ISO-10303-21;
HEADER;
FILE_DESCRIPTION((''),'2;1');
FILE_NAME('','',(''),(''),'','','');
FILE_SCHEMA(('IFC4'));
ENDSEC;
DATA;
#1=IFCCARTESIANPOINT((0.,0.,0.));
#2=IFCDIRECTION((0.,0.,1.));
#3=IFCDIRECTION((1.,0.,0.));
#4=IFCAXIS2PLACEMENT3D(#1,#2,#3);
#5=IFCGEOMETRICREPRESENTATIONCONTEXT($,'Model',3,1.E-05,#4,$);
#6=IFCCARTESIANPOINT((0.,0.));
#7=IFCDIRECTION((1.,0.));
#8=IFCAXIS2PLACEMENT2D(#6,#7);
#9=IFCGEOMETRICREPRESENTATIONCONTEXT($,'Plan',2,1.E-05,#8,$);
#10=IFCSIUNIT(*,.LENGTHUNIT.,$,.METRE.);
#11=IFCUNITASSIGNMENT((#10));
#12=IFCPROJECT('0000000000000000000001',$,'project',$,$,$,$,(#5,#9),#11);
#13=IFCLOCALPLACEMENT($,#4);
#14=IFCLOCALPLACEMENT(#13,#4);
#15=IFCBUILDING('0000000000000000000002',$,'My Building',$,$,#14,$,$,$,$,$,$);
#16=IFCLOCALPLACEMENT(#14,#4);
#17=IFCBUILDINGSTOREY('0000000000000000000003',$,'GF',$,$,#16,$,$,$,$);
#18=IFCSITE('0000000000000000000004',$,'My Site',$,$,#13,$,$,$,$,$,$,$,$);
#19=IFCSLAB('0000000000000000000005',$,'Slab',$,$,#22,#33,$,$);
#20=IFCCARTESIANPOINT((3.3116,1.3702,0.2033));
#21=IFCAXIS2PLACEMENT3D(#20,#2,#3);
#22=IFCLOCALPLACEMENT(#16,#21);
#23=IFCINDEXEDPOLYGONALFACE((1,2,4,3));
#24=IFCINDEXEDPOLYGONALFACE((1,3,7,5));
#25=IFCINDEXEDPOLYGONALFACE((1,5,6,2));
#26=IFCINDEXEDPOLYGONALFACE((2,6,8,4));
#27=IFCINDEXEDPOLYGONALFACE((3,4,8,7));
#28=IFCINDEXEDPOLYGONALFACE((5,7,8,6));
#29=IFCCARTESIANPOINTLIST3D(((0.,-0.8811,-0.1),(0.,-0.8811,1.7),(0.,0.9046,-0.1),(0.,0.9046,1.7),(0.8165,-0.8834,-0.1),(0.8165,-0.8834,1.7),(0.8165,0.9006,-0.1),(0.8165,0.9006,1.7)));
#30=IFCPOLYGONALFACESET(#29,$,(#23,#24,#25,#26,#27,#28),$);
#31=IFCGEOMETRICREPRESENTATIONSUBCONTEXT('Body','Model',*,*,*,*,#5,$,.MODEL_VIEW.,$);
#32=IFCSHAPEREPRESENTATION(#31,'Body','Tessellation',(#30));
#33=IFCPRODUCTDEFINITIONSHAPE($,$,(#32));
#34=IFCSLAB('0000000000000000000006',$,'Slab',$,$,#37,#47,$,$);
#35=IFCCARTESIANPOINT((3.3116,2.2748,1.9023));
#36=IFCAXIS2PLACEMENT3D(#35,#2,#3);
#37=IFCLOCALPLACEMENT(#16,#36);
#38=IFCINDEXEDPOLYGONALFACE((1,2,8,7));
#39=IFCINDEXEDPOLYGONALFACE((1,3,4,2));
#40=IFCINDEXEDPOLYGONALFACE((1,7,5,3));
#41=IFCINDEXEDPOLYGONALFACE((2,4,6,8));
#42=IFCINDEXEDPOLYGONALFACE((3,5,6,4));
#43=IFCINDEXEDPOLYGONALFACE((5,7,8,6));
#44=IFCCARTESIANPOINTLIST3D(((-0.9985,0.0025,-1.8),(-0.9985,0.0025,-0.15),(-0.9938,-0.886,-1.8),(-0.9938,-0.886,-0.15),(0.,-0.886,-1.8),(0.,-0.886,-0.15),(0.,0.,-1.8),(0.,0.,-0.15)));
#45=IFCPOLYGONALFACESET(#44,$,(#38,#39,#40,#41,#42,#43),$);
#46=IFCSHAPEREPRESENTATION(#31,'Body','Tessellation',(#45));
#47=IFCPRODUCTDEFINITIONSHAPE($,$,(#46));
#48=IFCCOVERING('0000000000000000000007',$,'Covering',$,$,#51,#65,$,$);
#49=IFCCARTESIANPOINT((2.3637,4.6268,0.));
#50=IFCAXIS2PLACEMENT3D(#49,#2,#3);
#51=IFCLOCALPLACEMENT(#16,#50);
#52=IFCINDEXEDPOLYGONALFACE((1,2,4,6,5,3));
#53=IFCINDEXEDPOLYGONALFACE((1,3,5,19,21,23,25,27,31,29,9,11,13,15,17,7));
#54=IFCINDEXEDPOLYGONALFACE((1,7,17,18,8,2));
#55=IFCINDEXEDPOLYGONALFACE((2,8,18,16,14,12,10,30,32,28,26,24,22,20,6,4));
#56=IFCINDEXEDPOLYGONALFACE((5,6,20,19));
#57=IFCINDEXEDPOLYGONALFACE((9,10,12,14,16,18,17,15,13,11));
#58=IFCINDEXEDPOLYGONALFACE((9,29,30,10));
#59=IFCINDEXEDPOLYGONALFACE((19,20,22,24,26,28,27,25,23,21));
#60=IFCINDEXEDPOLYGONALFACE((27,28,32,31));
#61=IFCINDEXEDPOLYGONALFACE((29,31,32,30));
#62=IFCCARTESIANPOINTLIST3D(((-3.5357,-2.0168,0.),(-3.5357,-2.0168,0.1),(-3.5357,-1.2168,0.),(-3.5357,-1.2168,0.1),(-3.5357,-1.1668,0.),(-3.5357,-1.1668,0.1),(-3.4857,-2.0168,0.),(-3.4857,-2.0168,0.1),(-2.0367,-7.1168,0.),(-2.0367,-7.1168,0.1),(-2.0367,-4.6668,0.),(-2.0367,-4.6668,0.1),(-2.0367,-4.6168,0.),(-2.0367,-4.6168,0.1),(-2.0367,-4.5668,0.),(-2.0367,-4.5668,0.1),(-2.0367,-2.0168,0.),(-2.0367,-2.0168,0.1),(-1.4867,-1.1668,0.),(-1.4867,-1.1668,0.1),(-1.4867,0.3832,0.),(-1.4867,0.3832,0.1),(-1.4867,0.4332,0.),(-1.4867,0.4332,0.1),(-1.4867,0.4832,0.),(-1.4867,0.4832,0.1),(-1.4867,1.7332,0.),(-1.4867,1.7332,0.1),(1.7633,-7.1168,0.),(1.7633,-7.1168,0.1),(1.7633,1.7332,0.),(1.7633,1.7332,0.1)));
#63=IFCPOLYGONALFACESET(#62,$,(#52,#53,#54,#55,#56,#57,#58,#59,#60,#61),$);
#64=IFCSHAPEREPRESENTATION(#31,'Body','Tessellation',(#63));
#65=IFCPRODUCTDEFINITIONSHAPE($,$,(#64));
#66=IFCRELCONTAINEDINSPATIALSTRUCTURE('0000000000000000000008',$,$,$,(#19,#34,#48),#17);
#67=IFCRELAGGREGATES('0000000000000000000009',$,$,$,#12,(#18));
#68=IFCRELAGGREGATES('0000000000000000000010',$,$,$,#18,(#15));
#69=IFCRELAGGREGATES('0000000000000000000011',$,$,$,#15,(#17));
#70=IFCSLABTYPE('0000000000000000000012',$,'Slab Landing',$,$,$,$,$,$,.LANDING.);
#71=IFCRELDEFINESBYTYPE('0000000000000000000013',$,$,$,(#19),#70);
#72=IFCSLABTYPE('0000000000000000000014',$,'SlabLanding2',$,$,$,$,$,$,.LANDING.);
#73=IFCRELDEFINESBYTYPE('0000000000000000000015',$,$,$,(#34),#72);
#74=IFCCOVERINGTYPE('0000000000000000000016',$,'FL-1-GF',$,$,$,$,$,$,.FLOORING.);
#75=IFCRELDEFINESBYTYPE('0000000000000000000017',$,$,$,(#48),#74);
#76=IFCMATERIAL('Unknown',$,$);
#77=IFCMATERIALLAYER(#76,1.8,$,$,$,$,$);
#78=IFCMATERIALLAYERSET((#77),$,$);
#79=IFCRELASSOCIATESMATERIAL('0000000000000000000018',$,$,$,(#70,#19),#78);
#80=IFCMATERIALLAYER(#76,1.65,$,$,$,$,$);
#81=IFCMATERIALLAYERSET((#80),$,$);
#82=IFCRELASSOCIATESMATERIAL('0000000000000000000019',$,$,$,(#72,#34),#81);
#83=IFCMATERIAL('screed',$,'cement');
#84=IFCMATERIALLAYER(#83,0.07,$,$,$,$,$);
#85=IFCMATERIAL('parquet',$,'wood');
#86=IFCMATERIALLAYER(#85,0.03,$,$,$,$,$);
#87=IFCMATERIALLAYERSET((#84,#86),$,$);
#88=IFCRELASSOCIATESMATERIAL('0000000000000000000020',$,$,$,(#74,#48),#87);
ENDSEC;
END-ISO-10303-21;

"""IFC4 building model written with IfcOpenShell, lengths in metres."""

from ifc_helpers import new_model, si_unit, frame, origin_with_axes, origin_2d_with_axis, place, context, subcontext, project, spatial, line, indexed_curve, outline, extrude, material, layer, layer_set, layer_usage, type_object, element, save


model = new_model("IFC4")

# Units and contexts
model_context = context("Model", 3, precision=1e-05, world=origin_with_axes())
plan_context = context("Plan", 2, precision=1e-05, world=origin_2d_with_axis())
body_context_1 = subcontext(model_context, "Body", "Model", "MODEL_VIEW")
ifc_project = project(units=[si_unit("LENGTHUNIT", "METRE")], contexts=[model_context, plan_context])

# Site, building, storey
site_placement = place(None, origin_with_axes())
site = spatial("IfcSite", under=ifc_project, at=site_placement, Name="My Site")
building_placement = place(site_placement, origin_with_axes())
building = spatial("IfcBuilding", under=site, at=building_placement, Name="My Building")
storey_placement = place(building_placement, origin_with_axes())
storey = spatial("IfcBuildingStorey", under=building, at=storey_placement, Name="GF")

# Slabs
ifc_material_1 = material(Name="Unknown")
ifc_layer_1 = layer(ifc_material_1, 1.8)
ifc_layer_set_1 = layer_set([ifc_layer_1])
ifc_layer_usage_1 = layer_usage(ifc_layer_set_1, "AXIS3", "POSITIVE", -0.1)
slab_type_1 = type_object("IfcSlabType", Name="Slab Landing", PredefinedType="LANDING", material=ifc_layer_set_1)
slab_1_placement = place(storey_placement, frame((3.3116, 1.3702, 0.2033), z_axis=(0.0, 0.0, 1.0), x_axis=(1.0, 0.0, 0.0)))
element("IfcSlab", 1, at=slab_1_placement, inside=storey, type_object=slab_type_1, material=ifc_layer_usage_1, Name="Slab", context=body_context_1, shape_type="SweptSolid", body=[
    extrude(outline(indexed_curve([(0.0, -0.8811), (0.8165, -0.8834), (0.8165, 0.9006), (0.0, 0.9046), (0.0, -0.8811)])), frame((0.0, 0.0, -0.1), z_axis=(0.0, 0.0, 1.0), x_axis=(1.0, 0.0, 0.0)), (0.0, 0.0, 1.0), 1.8),
])
ifc_layer_2 = layer(ifc_material_1, 1.65)
ifc_layer_set_2 = layer_set([ifc_layer_2])
ifc_layer_usage_2 = layer_usage(ifc_layer_set_2, "AXIS3", "POSITIVE", -1.8)
slab_type_2 = type_object("IfcSlabType", Name="SlabLanding2", PredefinedType="LANDING", material=ifc_layer_set_2)
slab_2_placement = place(storey_placement, frame((3.3116, 2.2748, 1.9023), z_axis=(0.0, 0.0, 1.0), x_axis=(1.0, 0.0, 0.0)))
element("IfcSlab", 2, at=slab_2_placement, inside=storey, type_object=slab_type_2, material=ifc_layer_usage_2, Name="Slab", context=body_context_1, shape_type="SweptSolid", body=[
    extrude(outline(indexed_curve([(0.0, 0.0), (0.0, -0.886), (-0.9938, -0.886), (-0.9985, 0.0025), (0.0, 0.0)])), frame((0.0, 0.0, -1.8), z_axis=(0.0, 0.0, 1.0), x_axis=(1.0, 0.0, 0.0)), (0.0, 0.0, 1.0), 1.65),
])

# Covering
ifc_material_2 = material(Name="screed", Category="cement")
ifc_layer_3 = layer(ifc_material_2, 0.07)
ifc_material_3 = material(Name="parquet", Category="wood")
ifc_layer_4 = layer(ifc_material_3, 0.03)
ifc_layer_set_3 = layer_set([ifc_layer_3, ifc_layer_4])
ifc_layer_usage_3 = layer_usage(ifc_layer_set_3, "AXIS3", "POSITIVE", 0.0)
covering_type = type_object("IfcCoveringType", Name="FL-1-GF", PredefinedType="FLOORING", material=ifc_layer_set_3)
covering_placement = place(storey_placement, frame((2.3637, 4.6268, 0.0), z_axis=(0.0, 0.0, 1.0), x_axis=(1.0, 0.0, 0.0)))
element("IfcCovering", 3, at=covering_placement, inside=storey, type_object=covering_type, material=ifc_layer_usage_3, Name="Covering", context=body_context_1, shape_type="SweptSolid", body=[
    extrude(outline(indexed_curve([(-1.4867, 1.7332), (1.7633, 1.7332), (1.7633, -7.1168), (-2.0367, -7.1168), (-2.0367, -4.6668), (-2.0367, -4.6168), (-2.0367, -4.6168), (-2.0367, -4.5668), (-2.0367, -2.0168), (-3.4857, -2.0168), (-3.5357, -2.0168), (-3.5357, -1.2168), (-3.5357, -1.1668), (-1.4867, -1.1668), (-1.4867, 0.3832), (-1.4867, 0.4332), (-1.4867, 0.4832)], segments=[line(1, 2, 3, 4, 5, 6, 7, 8, 9, 10, 11, 12, 13, 14, 15, 16, 17, 1)])), origin_with_axes(), (0.0, 0.0, 1.0), 0.1),
])

save(model, "model.ifc")
